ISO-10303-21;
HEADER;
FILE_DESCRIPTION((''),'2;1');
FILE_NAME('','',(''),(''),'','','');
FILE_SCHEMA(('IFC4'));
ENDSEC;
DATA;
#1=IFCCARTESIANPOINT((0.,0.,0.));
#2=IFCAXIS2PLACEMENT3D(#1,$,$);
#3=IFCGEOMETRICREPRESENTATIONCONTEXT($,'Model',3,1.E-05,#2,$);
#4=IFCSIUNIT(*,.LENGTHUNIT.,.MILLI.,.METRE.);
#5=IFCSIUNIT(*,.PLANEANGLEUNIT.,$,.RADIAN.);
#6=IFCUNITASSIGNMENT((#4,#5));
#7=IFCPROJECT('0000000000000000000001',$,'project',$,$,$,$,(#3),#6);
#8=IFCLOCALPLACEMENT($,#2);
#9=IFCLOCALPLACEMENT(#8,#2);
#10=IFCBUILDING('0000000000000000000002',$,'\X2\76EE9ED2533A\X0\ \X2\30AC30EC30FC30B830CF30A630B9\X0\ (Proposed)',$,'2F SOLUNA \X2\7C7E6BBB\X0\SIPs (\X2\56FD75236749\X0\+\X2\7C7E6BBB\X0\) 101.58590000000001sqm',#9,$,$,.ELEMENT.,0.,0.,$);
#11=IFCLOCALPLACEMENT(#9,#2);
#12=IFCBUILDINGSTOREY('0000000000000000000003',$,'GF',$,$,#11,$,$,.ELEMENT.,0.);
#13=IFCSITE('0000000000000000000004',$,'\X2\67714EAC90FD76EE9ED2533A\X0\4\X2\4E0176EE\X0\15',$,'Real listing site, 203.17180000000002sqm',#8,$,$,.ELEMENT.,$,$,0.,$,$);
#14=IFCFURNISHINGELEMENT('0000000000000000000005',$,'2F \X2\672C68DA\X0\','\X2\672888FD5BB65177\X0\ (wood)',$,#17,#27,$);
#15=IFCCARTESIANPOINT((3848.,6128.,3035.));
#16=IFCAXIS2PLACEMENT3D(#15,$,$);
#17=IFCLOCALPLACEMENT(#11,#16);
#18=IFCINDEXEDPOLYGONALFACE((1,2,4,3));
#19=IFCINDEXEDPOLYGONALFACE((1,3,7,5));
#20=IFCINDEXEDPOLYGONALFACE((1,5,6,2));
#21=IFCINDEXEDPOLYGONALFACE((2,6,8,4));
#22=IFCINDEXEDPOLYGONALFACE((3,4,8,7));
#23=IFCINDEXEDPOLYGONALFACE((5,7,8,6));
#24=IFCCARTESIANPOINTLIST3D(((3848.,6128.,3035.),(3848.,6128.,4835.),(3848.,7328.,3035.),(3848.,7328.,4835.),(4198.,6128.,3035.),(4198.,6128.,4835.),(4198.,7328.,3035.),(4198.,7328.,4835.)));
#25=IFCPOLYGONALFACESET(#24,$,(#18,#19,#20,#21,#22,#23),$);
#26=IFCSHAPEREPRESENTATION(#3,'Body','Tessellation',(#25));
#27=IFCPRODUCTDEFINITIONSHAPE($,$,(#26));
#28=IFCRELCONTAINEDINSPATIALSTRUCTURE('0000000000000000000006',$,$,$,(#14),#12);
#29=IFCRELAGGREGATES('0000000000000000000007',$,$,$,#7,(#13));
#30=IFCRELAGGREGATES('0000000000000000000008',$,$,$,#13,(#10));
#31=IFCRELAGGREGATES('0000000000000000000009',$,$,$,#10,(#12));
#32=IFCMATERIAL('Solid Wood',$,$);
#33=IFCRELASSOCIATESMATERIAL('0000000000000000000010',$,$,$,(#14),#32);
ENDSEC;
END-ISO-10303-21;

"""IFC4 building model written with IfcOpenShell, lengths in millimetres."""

from ifc_helpers import new_model, si_unit, frame, frame_2d, origin, place, context, project, spatial, rectangle, extrude, material, element, save


model = new_model("IFC4")

# Units and contexts
model_context = context("Model", 3, precision=1e-05, world=origin())
ifc_project = project(units=[si_unit("LENGTHUNIT", "METRE", prefix="MILLI"), si_unit("PLANEANGLEUNIT", "RADIAN")], contexts=[model_context])

# Site, building, storey
site_placement = place(None, origin())
site = spatial("IfcSite", under=ifc_project, at=site_placement, Name="東京都目黒区4丁目15", ObjectType="Real listing site, 203.17180000000002sqm", CompositionType="ELEMENT", RefElevation=0.0)
building_placement = place(site_placement, origin())
building = spatial("IfcBuilding", under=site, at=building_placement, Name="目黒区 ガレージハウス (Proposed)", ObjectType="2F SOLUNA 籾殻SIPs (国産杉+籾殻) 101.58590000000001sqm", CompositionType="ELEMENT", ElevationOfRefHeight=0.0, ElevationOfTerrain=0.0)
storey_placement = place(building_placement, origin())
storey = spatial("IfcBuildingStorey", under=building, at=storey_placement, Name="GF", CompositionType="ELEMENT", Elevation=0.0)

# Shared definitions
ifc_material_1 = material(Name="Solid Wood")

# Furnishing element
furnishing_1_placement = place(storey_placement, frame((3848.0, 6128.0, 3035.0)))
element("IfcFurnishingElement", 1, at=furnishing_1_placement, inside=storey, material=ifc_material_1, Name="2F 本棚", Description="木製家具 (wood)", context=model_context, shape_type="SweptSolid", body=[
    extrude(rectangle(XDim=350.0, YDim=1200.0, at=frame_2d((175.0, 600.0))), frame((3848.0, 6128.0, 3035.0)), (0.0, 0.0, 1.0), 1800.0),
])

save(model, "model.ifc")
